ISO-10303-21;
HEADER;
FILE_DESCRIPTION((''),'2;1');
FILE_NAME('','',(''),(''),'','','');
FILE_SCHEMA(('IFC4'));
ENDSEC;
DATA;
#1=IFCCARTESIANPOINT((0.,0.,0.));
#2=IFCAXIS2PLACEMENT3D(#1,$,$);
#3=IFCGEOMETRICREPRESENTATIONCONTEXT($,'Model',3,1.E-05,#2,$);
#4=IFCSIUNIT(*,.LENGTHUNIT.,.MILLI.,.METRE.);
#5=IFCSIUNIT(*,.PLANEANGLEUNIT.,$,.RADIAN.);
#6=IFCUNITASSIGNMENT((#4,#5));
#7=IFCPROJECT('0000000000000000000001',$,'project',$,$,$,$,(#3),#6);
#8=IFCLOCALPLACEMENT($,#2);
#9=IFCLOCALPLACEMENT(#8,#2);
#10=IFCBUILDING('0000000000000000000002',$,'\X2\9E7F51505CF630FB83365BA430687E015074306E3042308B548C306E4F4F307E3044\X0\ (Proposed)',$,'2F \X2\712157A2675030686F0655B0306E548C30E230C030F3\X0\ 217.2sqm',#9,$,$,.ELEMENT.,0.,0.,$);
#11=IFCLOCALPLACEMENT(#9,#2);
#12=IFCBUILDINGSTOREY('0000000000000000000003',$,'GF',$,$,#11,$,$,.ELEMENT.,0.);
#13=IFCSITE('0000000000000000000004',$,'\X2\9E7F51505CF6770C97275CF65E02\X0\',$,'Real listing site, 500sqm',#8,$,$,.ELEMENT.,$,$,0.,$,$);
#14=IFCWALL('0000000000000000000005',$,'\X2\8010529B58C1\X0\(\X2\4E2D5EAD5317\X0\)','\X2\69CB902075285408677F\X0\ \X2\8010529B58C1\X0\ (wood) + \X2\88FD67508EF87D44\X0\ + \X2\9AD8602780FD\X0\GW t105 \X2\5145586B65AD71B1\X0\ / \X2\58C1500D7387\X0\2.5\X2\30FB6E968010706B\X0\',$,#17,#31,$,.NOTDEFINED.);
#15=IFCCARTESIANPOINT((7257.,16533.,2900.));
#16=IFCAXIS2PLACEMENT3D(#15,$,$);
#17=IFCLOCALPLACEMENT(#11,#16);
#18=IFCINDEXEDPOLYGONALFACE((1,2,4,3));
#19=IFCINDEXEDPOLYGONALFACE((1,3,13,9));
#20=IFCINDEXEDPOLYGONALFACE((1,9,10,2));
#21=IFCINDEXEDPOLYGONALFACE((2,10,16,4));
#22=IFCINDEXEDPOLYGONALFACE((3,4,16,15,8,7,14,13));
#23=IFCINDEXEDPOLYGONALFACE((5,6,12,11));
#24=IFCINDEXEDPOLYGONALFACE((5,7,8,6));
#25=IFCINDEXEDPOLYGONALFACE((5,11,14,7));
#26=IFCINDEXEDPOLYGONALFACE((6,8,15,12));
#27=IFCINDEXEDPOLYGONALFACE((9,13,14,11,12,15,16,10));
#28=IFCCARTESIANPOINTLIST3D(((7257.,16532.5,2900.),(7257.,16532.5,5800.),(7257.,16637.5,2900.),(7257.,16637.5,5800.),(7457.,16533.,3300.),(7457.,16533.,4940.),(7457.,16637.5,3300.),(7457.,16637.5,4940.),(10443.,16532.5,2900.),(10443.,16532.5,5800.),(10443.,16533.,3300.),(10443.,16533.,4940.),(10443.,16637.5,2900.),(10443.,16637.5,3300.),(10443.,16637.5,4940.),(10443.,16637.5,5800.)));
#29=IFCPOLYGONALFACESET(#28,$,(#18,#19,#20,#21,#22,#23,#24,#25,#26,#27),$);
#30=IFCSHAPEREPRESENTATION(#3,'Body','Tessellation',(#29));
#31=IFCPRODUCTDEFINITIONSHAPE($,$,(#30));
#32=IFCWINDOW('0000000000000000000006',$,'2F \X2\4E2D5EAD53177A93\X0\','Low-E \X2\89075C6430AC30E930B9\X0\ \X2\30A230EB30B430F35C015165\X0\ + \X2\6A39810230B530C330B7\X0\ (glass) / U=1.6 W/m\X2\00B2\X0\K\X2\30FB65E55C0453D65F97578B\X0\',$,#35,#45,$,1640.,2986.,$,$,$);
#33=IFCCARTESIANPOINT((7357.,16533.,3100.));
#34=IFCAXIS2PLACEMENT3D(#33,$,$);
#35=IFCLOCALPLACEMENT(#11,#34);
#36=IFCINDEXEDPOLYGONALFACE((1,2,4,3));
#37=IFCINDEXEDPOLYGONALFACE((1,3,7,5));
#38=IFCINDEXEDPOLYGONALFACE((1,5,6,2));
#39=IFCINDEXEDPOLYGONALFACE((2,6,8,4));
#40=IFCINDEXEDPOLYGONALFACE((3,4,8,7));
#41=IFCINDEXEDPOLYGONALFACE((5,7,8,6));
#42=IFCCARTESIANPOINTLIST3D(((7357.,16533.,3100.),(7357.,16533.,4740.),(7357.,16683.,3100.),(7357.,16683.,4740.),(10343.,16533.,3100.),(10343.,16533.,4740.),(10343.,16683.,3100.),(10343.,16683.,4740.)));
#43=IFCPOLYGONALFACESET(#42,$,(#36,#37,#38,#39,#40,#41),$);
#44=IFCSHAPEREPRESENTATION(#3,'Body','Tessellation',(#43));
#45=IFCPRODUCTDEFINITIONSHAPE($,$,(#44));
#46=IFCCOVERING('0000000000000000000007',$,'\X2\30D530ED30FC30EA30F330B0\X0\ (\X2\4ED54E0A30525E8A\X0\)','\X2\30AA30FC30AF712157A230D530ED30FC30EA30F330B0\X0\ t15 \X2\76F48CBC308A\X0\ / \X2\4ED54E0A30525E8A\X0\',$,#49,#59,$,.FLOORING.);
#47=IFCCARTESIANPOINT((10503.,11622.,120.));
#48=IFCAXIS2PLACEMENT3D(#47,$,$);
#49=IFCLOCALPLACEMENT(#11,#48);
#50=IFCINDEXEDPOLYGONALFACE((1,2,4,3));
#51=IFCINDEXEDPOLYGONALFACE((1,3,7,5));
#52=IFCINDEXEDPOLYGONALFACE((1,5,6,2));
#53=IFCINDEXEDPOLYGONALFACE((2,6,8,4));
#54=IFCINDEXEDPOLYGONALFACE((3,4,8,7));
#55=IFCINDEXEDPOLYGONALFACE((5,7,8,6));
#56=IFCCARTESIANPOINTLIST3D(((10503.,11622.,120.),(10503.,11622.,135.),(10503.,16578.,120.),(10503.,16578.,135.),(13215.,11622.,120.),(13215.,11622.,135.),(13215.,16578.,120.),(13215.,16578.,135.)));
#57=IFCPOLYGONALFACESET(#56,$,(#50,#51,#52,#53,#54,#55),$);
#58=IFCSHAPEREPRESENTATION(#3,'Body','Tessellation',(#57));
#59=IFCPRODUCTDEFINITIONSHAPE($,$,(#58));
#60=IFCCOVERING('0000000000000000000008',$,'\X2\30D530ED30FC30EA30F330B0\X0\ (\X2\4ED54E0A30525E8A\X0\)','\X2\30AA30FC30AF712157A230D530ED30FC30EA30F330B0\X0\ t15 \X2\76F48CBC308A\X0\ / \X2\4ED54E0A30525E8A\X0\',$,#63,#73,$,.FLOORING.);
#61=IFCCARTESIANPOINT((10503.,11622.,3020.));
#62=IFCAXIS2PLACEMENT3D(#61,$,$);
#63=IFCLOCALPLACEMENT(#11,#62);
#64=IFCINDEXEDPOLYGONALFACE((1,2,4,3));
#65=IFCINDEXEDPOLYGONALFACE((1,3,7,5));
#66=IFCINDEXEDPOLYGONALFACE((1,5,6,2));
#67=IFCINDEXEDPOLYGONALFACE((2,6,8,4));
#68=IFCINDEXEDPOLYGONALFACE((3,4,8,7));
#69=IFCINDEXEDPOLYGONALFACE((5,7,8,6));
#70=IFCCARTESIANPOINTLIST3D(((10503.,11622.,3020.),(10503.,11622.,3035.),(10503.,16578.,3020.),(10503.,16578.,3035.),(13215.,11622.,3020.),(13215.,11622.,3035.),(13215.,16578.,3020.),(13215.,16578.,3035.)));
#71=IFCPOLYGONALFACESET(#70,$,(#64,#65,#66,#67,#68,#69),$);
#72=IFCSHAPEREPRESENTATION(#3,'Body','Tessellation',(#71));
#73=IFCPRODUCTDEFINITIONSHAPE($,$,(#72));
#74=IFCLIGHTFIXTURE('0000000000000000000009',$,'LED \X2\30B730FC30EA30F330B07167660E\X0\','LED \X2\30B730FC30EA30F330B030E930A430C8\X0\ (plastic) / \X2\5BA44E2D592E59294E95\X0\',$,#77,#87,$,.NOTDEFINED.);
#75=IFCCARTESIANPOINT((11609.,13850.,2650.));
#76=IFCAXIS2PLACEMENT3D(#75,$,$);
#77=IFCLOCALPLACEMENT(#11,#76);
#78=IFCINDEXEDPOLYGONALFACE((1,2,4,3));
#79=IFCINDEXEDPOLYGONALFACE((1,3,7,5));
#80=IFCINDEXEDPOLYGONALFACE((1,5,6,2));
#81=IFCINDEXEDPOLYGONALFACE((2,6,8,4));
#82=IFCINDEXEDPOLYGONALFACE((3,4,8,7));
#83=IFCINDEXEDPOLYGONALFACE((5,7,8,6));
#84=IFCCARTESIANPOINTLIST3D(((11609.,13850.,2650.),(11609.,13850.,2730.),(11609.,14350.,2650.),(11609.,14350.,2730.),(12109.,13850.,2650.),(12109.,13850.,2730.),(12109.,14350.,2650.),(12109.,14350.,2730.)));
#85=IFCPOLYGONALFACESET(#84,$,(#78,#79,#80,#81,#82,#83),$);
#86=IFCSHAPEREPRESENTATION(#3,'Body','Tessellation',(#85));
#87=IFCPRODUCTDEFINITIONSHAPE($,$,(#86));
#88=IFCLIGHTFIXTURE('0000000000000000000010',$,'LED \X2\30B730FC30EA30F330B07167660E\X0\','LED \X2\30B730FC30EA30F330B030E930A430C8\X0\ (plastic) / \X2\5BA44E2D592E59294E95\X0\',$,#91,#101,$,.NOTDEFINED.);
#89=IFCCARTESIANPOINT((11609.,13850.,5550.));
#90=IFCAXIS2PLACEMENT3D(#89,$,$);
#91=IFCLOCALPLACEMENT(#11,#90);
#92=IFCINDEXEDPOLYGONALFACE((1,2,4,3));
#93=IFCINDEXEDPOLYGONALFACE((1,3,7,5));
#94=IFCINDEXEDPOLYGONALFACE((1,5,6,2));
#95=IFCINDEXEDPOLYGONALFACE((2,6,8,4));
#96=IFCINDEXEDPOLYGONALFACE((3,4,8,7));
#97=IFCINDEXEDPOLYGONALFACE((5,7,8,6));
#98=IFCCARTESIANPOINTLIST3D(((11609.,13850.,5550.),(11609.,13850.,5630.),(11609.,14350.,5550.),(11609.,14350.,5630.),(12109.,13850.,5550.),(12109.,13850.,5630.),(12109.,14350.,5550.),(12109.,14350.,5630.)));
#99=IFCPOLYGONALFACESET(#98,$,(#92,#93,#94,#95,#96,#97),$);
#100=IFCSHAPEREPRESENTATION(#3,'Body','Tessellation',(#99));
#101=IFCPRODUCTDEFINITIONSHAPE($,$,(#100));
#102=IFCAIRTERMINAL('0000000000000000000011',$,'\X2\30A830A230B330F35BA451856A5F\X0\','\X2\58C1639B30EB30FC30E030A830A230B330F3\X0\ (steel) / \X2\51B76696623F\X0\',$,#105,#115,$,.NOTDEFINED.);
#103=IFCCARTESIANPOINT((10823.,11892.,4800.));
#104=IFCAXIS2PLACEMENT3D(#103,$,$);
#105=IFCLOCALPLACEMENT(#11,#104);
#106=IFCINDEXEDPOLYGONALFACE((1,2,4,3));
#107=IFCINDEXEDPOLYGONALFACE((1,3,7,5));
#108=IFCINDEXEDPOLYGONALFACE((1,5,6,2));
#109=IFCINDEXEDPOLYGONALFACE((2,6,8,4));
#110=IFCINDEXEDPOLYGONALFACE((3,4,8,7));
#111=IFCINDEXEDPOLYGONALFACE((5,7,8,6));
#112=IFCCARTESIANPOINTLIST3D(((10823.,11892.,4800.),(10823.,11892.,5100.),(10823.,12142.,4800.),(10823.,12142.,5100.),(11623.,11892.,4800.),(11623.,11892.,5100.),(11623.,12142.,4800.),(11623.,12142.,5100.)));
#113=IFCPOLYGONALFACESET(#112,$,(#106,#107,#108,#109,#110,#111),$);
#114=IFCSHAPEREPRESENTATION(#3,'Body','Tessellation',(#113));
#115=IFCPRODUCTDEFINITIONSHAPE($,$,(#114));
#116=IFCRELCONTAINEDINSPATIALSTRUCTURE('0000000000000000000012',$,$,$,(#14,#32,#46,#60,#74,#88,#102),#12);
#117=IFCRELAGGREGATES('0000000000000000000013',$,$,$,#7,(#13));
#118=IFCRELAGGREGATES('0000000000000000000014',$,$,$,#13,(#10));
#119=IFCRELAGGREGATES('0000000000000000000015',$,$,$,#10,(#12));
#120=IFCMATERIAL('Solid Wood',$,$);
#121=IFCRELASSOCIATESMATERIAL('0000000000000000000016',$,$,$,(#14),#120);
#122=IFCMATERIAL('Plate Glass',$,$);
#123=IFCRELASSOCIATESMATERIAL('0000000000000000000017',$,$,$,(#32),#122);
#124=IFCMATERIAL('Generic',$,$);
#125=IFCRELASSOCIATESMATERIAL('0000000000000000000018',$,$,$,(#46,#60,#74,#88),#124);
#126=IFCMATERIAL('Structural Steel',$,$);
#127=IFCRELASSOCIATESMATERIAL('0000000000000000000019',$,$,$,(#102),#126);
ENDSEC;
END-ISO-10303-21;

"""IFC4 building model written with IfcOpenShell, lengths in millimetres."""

from ifc_helpers import new_model, si_unit, frame, frame_2d, origin, place, context, project, spatial, rectangle, extrude, material, element, fill, save


model = new_model("IFC4")

# Units and contexts
model_context = context("Model", 3, precision=1e-05, world=origin())
ifc_project = project(units=[si_unit("LENGTHUNIT", "METRE", prefix="MILLI"), si_unit("PLANEANGLEUNIT", "RADIAN")], contexts=[model_context])

# Site, building, storey
site_placement = place(None, origin())
site = spatial("IfcSite", under=ifc_project, at=site_placement, Name="鹿児島県霧島市", ObjectType="Real listing site, 500sqm", CompositionType="ELEMENT", RefElevation=0.0)
building_placement = place(site_placement, origin())
building = spatial("IfcBuilding", under=site, at=building_placement, Name="鹿児島・茶室と縁側のある和の住まい (Proposed)", ObjectType="2F 無垢材と漆喰の和モダン 217.2sqm", CompositionType="ELEMENT", ElevationOfRefHeight=0.0, ElevationOfTerrain=0.0)
storey_placement = place(building_placement, origin())
storey = spatial("IfcBuildingStorey", under=building, at=storey_placement, Name="GF", CompositionType="ELEMENT", Elevation=0.0)

# Shared definitions
ifc_material_1 = material(Name="Solid Wood")
ifc_material_2 = material(Name="Structural Steel")

# Wall, opening, window
ifc_material_3 = material(Name="Plate Glass")
wall_1_placement = place(storey_placement, frame((7257.0, 16533.0, 2900.0)))
wall_1 = element("IfcWall", 1, at=wall_1_placement, inside=storey, material=ifc_material_1, Name="耐力壁(中庭北)", Description="構造用合板 耐力壁 (wood) + 製材軸組 + 高性能GW t105 充填断熱 / 壁倍率2.5・準耐火", PredefinedType="NOTDEFINED", context=model_context, shape_type="SweptSolid", body=[
    extrude(rectangle(XDim=3186.0, YDim=105.0, at=frame_2d((1593.0, 52.0))), frame((7257.0, 16533.0, 2900.0)), (0.0, 0.0, 1.0), 2900.0),
])
opening_1_placement = place(storey_placement, frame((7357.0, 16533.0, 3100.0)))
opening_1 = element("IfcOpeningElement", 2, at=opening_1_placement, cuts=wall_1, PredefinedType="NOTDEFINED", context=model_context, shape_type="SweptSolid", body=[
    extrude(rectangle(XDim=2986.0, YDim=150.0, at=frame_2d((1493.0, 75.0))), frame((7357.0, 16533.0, 3100.0)), (0.0, 0.0, 1.0), 1640.0),
])
window_1_placement = place(storey_placement, frame((7357.0, 16533.0, 3100.0)))
window_1 = element("IfcWindow", 3, at=window_1_placement, inside=storey, material=ifc_material_3, Name="2F 中庭北窓", Description="Low-E 複層ガラス アルゴン封入 + 樹脂サッシ (glass) / U=1.6 W/m²K・日射取得型", OverallHeight=1640.0, OverallWidth=2986.0, context=model_context, shape_type="SweptSolid", body=[
    extrude(rectangle(XDim=2986.0, YDim=150.0, at=frame_2d((1493.0, 75.0))), frame((7357.0, 16533.0, 3100.0)), (0.0, 0.0, 1.0), 1640.0),
])
fill(opening_1, window_1)

# Coverings
ifc_material_4 = material(Name="Generic")
covering_1_placement = place(storey_placement, frame((10503.0, 11622.0, 120.0)))
element("IfcCovering", 4, at=covering_1_placement, inside=storey, material=ifc_material_4, Name="フローリング (仕上げ床)", Description="オーク無垢フローリング t15 直貼り / 仕上げ床", PredefinedType="FLOORING", context=model_context, shape_type="SweptSolid", body=[
    extrude(rectangle(XDim=2712.0, YDim=4956.0, at=frame_2d((1356.0, 2478.0))), frame((10503.0, 11622.0, 120.0)), (0.0, 0.0, 1.0), 15.0),
])
covering_2_placement = place(storey_placement, frame((10503.0, 11622.0, 3020.0)))
element("IfcCovering", 5, at=covering_2_placement, inside=storey, material=ifc_material_4, Name="フローリング (仕上げ床)", Description="オーク無垢フローリング t15 直貼り / 仕上げ床", PredefinedType="FLOORING", context=model_context, shape_type="SweptSolid", body=[
    extrude(rectangle(XDim=2712.0, YDim=4956.0, at=frame_2d((1356.0, 2478.0))), frame((10503.0, 11622.0, 3020.0)), (0.0, 0.0, 1.0), 15.0),
])

# Light fixtures
light_fixture_1_placement = place(storey_placement, frame((11609.0, 13850.0, 2650.0)))
element("IfcLightFixture", 6, at=light_fixture_1_placement, inside=storey, material=ifc_material_4, Name="LED シーリング照明", Description="LED シーリングライト (plastic) / 室中央天井", PredefinedType="NOTDEFINED", context=model_context, shape_type="SweptSolid", body=[
    extrude(rectangle(XDim=500.0, YDim=500.0, at=frame_2d((250.0, 250.0))), frame((11609.0, 13850.0, 2650.0)), (0.0, 0.0, 1.0), 80.0),
])
light_fixture_2_placement = place(storey_placement, frame((11609.0, 13850.0, 5550.0)))
element("IfcLightFixture", 7, at=light_fixture_2_placement, inside=storey, material=ifc_material_4, Name="LED シーリング照明", Description="LED シーリングライト (plastic) / 室中央天井", PredefinedType="NOTDEFINED", context=model_context, shape_type="SweptSolid", body=[
    extrude(rectangle(XDim=500.0, YDim=500.0, at=frame_2d((250.0, 250.0))), frame((11609.0, 13850.0, 5550.0)), (0.0, 0.0, 1.0), 80.0),
])

# Air terminal
air_terminal_placement = place(storey_placement, frame((10823.0, 11892.0, 4800.0)))
element("IfcAirTerminal", 8, at=air_terminal_placement, inside=storey, material=ifc_material_2, Name="エアコン室内機", Description="壁掛ルームエアコン (steel) / 冷暖房", PredefinedType="NOTDEFINED", context=model_context, shape_type="SweptSolid", body=[
    extrude(rectangle(XDim=800.0, YDim=250.0, at=frame_2d((400.0, 125.0))), frame((10823.0, 11892.0, 4800.0)), (0.0, 0.0, 1.0), 300.0),
])

save(model, "model.ifc")
